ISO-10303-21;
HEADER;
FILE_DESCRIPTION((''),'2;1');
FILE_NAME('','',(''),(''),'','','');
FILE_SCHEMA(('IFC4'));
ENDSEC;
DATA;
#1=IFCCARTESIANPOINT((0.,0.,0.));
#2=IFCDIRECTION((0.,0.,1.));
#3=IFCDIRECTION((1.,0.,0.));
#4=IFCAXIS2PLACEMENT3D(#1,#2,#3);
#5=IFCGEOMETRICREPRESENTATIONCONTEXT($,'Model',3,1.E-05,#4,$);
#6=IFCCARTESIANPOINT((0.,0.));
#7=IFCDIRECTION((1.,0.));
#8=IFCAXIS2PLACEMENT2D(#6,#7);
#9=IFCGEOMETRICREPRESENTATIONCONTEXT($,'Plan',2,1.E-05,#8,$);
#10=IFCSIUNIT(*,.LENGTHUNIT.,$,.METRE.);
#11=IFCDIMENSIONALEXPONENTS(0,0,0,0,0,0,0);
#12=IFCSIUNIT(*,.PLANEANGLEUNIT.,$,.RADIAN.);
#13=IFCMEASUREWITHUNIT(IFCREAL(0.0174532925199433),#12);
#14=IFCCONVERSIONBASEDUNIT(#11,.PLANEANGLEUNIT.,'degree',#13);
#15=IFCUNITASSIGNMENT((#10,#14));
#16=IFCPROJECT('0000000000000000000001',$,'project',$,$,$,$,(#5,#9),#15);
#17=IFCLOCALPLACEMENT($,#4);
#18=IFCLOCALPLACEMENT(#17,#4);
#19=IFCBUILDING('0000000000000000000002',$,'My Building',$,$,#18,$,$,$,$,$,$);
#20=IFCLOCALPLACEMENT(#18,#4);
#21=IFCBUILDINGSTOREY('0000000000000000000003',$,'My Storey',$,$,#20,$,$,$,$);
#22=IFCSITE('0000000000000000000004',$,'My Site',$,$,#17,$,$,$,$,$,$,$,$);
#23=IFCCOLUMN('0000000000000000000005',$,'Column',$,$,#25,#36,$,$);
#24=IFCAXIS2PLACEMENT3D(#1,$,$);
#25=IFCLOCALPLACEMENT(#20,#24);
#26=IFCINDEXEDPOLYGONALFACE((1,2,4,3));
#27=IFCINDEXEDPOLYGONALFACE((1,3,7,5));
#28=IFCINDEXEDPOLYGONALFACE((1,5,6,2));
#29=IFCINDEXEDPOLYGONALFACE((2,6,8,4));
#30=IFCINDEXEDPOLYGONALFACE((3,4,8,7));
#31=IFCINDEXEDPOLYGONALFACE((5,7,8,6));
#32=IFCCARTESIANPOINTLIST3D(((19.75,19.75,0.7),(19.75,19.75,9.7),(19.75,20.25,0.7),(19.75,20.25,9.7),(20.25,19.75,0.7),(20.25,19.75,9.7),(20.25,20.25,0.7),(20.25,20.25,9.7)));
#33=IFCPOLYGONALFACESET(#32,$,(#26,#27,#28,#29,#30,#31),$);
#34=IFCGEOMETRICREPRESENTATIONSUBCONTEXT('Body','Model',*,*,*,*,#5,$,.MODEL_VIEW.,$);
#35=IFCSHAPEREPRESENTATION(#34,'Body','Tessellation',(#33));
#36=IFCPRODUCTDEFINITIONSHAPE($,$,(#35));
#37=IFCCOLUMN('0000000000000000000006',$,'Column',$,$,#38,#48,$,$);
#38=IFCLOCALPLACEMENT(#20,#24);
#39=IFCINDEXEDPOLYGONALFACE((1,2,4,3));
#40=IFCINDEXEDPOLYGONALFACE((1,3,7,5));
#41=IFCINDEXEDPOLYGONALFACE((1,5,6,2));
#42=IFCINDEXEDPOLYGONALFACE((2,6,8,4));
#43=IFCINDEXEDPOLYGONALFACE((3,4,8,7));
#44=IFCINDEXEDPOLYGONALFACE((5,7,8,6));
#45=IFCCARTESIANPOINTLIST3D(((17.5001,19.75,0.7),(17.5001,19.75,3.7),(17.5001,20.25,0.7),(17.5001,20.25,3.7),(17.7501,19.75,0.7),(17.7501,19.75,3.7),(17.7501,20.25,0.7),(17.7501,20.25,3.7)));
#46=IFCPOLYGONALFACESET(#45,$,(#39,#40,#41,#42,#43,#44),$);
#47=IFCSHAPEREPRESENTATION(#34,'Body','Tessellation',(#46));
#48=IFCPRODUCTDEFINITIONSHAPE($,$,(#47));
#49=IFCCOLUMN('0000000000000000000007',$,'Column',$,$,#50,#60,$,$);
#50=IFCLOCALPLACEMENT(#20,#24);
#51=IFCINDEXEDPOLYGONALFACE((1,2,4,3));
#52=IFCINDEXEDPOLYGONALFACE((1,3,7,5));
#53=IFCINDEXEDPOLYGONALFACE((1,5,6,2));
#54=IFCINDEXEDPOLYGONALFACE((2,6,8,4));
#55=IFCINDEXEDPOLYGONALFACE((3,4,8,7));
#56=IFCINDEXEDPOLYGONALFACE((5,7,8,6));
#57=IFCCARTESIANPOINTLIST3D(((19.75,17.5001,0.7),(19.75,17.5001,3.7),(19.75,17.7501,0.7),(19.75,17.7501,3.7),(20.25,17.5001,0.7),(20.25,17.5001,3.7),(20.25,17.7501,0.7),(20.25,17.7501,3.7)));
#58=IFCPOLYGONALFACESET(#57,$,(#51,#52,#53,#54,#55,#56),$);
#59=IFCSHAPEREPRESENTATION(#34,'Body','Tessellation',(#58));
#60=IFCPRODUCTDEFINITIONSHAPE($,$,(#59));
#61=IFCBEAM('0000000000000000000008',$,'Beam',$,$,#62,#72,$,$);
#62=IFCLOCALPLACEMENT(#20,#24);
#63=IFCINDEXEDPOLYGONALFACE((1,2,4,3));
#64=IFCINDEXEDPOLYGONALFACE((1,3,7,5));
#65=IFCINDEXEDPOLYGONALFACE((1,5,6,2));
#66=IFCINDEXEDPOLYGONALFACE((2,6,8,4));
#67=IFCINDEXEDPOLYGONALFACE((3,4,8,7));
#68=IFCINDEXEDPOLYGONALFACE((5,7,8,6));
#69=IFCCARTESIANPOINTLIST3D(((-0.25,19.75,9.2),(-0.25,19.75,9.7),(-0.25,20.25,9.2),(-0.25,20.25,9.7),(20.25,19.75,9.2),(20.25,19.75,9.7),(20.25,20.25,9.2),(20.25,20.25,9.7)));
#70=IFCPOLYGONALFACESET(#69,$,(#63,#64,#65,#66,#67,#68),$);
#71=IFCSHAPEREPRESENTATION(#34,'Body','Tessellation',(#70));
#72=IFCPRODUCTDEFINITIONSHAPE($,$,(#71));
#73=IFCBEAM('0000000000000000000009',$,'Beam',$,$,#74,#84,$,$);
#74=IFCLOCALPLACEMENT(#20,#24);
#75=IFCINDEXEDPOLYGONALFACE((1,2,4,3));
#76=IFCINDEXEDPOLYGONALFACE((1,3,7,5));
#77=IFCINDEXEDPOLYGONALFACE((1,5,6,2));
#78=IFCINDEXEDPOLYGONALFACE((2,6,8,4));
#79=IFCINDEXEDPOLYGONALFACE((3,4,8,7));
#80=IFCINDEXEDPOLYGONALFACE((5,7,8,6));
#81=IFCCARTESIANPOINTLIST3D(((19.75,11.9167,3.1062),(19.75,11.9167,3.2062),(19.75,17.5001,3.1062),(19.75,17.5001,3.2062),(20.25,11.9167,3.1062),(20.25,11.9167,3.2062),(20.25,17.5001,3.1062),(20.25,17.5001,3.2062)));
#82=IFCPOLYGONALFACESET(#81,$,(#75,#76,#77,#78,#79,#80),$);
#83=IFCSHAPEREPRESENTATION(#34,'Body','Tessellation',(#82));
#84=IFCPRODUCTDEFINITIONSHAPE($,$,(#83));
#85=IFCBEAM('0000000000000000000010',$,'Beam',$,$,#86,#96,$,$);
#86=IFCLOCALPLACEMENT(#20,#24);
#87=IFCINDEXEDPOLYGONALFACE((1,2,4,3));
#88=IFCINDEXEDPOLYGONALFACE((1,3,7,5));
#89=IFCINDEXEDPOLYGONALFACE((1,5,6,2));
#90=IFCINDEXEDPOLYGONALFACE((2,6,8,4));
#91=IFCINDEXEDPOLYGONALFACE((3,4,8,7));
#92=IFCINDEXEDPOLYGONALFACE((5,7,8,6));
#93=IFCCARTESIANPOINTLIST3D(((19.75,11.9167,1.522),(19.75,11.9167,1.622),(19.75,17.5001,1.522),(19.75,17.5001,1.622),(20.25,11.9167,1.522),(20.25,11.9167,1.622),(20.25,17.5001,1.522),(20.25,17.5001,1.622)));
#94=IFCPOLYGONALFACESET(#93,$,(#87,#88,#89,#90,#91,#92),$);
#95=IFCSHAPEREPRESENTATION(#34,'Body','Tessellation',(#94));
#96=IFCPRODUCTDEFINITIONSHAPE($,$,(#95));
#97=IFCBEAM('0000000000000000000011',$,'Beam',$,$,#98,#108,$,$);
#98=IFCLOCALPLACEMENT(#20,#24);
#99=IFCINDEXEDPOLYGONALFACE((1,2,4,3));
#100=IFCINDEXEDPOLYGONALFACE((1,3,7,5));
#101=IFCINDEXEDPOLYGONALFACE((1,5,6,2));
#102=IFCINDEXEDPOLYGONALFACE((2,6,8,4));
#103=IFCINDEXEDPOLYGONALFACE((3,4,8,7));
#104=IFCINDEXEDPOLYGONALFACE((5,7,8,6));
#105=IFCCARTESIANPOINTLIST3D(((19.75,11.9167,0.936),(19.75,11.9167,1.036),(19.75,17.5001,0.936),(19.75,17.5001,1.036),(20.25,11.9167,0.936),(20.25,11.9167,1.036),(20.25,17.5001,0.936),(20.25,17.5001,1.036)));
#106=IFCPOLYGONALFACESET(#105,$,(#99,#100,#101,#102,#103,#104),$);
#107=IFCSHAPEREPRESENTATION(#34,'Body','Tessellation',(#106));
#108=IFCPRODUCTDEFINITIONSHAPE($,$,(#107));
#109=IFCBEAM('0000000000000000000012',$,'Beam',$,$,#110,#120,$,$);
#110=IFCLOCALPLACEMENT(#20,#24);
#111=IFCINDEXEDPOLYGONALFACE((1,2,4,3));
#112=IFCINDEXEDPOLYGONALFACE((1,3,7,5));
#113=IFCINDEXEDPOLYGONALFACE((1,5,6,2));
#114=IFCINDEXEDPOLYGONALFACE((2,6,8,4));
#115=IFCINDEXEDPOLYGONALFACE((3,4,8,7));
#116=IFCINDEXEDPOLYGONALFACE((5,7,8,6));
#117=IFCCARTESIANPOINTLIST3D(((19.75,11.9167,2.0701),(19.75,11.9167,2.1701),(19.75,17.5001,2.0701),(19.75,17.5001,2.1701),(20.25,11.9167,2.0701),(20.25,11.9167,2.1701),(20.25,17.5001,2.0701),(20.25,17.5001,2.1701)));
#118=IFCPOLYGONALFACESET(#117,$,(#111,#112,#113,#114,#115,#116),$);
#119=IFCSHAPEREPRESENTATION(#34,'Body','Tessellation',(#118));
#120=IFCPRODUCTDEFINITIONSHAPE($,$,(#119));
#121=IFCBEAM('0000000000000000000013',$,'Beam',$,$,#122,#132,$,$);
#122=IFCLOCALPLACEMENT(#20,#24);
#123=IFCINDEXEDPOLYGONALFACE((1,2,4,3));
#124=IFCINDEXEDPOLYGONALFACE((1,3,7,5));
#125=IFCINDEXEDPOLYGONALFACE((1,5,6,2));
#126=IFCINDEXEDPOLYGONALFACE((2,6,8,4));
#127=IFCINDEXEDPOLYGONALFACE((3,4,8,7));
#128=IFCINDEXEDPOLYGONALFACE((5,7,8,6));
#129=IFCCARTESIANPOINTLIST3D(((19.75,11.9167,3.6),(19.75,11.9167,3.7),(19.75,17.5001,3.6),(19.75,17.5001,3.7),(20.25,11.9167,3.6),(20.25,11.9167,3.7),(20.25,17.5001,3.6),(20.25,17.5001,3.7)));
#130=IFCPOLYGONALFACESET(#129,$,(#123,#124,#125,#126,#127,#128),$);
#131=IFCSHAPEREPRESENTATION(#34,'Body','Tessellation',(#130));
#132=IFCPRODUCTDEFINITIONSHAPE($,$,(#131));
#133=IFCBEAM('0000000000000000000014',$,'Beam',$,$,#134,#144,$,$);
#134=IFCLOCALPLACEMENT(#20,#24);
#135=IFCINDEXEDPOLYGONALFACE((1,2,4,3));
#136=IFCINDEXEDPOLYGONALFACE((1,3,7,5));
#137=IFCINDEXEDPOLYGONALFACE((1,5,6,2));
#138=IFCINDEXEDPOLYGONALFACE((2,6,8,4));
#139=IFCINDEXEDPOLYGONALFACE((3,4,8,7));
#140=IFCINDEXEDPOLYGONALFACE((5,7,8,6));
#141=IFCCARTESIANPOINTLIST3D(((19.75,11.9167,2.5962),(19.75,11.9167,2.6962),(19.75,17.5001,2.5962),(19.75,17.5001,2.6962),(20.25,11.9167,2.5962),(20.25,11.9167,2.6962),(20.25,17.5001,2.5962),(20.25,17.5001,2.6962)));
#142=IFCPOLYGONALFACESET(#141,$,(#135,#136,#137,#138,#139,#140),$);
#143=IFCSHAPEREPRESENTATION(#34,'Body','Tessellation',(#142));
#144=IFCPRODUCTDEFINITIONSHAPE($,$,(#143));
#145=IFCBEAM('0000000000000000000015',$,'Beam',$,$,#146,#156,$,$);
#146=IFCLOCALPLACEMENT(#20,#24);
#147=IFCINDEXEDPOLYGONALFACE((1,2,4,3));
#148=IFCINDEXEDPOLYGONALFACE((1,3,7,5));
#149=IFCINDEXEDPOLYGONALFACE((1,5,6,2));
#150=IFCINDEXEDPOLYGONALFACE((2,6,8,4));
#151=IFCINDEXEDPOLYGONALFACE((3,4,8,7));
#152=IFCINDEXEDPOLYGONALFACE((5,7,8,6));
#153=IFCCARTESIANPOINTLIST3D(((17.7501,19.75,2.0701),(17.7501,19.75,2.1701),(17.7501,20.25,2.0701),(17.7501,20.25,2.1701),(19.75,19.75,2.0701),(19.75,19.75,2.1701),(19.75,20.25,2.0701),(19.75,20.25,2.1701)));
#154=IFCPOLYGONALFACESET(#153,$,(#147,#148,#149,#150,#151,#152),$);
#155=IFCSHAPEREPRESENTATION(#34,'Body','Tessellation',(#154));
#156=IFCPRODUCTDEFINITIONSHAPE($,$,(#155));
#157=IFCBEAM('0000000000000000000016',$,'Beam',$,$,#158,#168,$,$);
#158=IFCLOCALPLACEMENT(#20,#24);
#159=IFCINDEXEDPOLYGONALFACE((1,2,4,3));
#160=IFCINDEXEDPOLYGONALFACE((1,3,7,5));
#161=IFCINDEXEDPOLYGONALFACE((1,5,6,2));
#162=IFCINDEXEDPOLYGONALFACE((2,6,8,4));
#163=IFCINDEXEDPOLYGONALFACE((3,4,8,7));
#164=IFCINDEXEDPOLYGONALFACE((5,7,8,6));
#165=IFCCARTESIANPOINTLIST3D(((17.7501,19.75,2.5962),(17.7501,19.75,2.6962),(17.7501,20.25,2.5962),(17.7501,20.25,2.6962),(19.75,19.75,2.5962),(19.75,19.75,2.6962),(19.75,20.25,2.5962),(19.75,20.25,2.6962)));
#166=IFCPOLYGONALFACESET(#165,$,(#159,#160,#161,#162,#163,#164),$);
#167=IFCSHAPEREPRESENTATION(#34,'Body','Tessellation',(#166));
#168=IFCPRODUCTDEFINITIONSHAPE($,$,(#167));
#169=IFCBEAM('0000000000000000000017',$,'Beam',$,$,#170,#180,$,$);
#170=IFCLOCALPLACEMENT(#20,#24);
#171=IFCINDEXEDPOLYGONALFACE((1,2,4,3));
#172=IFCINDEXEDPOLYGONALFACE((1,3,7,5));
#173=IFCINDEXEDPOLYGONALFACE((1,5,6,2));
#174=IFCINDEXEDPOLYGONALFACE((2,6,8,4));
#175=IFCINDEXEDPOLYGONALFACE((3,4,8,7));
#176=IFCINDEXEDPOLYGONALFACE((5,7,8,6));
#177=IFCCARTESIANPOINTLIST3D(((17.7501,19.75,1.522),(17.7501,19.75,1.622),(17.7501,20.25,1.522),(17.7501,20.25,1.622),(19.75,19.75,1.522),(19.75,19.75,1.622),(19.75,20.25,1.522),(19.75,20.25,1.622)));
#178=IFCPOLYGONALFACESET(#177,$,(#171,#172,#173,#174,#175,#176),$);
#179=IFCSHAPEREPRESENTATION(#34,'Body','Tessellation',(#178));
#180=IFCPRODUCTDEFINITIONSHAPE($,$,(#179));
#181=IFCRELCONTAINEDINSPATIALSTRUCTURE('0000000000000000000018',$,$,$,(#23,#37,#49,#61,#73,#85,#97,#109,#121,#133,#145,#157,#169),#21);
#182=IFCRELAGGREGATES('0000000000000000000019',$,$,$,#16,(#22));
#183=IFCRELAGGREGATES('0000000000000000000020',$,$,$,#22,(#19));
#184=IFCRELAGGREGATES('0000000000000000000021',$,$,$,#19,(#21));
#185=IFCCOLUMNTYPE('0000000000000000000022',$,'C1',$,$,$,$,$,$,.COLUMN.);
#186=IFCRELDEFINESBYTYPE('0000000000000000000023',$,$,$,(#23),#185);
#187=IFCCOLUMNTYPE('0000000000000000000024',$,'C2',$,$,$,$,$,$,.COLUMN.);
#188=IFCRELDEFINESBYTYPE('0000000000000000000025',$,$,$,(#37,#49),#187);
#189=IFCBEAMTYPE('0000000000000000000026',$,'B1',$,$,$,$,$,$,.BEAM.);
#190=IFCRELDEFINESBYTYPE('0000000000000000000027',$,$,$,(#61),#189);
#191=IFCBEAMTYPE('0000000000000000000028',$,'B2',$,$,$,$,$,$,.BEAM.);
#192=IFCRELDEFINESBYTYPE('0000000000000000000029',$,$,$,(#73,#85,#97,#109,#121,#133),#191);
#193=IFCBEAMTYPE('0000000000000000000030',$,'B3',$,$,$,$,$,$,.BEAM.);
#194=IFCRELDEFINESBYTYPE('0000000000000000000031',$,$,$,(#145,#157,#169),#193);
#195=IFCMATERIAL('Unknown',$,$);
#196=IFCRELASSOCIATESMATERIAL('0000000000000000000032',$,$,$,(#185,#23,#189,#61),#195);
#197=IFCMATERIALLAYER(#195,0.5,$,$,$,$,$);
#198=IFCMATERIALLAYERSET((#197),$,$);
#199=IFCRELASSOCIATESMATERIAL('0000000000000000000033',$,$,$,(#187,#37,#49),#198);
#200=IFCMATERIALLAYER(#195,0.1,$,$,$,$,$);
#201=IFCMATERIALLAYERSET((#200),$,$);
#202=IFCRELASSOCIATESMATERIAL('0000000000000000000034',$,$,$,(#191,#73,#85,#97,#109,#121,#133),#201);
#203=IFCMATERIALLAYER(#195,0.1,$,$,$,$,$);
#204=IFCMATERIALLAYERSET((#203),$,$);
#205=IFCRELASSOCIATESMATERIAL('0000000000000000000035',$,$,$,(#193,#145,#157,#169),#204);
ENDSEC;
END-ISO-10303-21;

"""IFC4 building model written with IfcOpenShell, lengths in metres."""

from ifc_helpers import new_model, entity, si_unit, converted_unit, frame, origin_with_axes, origin_2d_with_axis, place, context, subcontext, project, spatial, line, indexed_curve, rectangle, outline, extrude, material, layer, layer_set, layer_usage, material_profile, profile_set, profile_usage, type_object, element, save


model = new_model("IFC4")

# Units and contexts
model_context = context("Model", 3, precision=1e-05, world=origin_with_axes())
plan_context = context("Plan", 2, precision=1e-05, world=origin_2d_with_axis())
body_context = subcontext(model_context, "Body", "Model", "MODEL_VIEW")
ifc_project = project(units=[si_unit("LENGTHUNIT", "METRE"), converted_unit("PLANEANGLEUNIT", "degree", entity("IfcReal", 0.0174532925199433), si_unit("PLANEANGLEUNIT", "RADIAN"), dimensions=[0, 0, 0, 0, 0, 0, 0])], contexts=[model_context, plan_context])

# Site, building, storey
site_placement = place(None, origin_with_axes())
site = spatial("IfcSite", under=ifc_project, at=site_placement, Name="My Site")
building_placement = place(site_placement, origin_with_axes())
building = spatial("IfcBuilding", under=site, at=building_placement, Name="My Building")
storey_placement = place(building_placement, origin_with_axes())
storey = spatial("IfcBuildingStorey", under=building, at=storey_placement, Name="My Storey")

# Columns
ifc_material = material(Name="Unknown")
ifc_material_profile_1 = material_profile(ifc_material, rectangle(XDim=0.5, YDim=0.5))
ifc_profile_set_1 = profile_set([ifc_material_profile_1])
ifc_profile_usage_1 = profile_usage(ifc_profile_set_1, cardinal=5)
column_type_1 = type_object("IfcColumnType", Name="C1", PredefinedType="COLUMN", material=ifc_profile_set_1)
column_1_placement = place(storey_placement, frame((20.0, 20.0, 0.7), z_axis=(0.0, 0.0, 1.0), x_axis=(1.0, 0.0, 0.0)))
element("IfcColumn", 1, at=column_1_placement, inside=storey, type_object=column_type_1, material=ifc_profile_usage_1, Name="Column", context=body_context, shape_type="SweptSolid", body=[
    extrude(rectangle(XDim=0.5, YDim=0.5), origin_with_axes(), (0.0, 0.0, 1.0), 9.0),
])
ifc_layer_1 = layer(ifc_material, 0.5)
ifc_layer_set_1 = layer_set([ifc_layer_1])
ifc_layer_usage_1 = layer_usage(ifc_layer_set_1, "AXIS2", "POSITIVE", 0.0)
column_type_2 = type_object("IfcColumnType", Name="C2", PredefinedType="COLUMN", material=ifc_layer_set_1)
column_2_placement = place(storey_placement, frame((17.5001, 19.75, 0.7), z_axis=(0.0, 0.0, 1.0), x_axis=(1.0, -0.000008, 0.0)))
element("IfcColumn", 2, at=column_2_placement, inside=storey, type_object=column_type_2, material=ifc_layer_usage_1, Name="Column", context=body_context, shape_type="SweptSolid", body=[
    extrude(outline(indexed_curve([(0.0, 0.0), (0.0, 0.5), (0.25, 0.5), (0.25, 0.0)], segments=[line(1, 2, 3, 4, 1)])), origin_with_axes(), (0.0, 0.0, 1.0), 3.0),
])
ifc_layer_usage_2 = layer_usage(ifc_layer_set_1, "AXIS2", "POSITIVE", 0.0)
column_3_placement = place(storey_placement, frame((20.25, 17.5001, 0.7), z_axis=(0.0, 0.0, 1.0), x_axis=(0.000007, 1.0, 0.0)))
element("IfcColumn", 3, at=column_3_placement, inside=storey, type_object=column_type_2, material=ifc_layer_usage_2, Name="Column", context=body_context, shape_type="SweptSolid", body=[
    extrude(outline(indexed_curve([(0.0, 0.0), (0.0, 0.5), (0.25, 0.5), (0.25, 0.0)], segments=[line(1, 2, 3, 4, 1)])), origin_with_axes(), (0.0, 0.0, 1.0), 3.0),
])

# Beams
ifc_material_profile_2 = material_profile(ifc_material, rectangle(XDim=0.5, YDim=0.5))
ifc_profile_set_2 = profile_set([ifc_material_profile_2])
ifc_profile_usage_2 = profile_usage(ifc_profile_set_2, cardinal=8)
beam_type_1 = type_object("IfcBeamType", Name="B1", PredefinedType="BEAM", material=ifc_profile_set_2)
beam_1_placement = place(storey_placement, frame((20.25, 20.0, 9.7), z_axis=(-1.0, -0.000001, 0.000001), x_axis=(0.000001, -1.0, 0.0)))
element("IfcBeam", 4, at=beam_1_placement, inside=storey, type_object=beam_type_1, material=ifc_profile_usage_2, Name="Beam", context=body_context, shape_type="SweptSolid", body=[
    extrude(rectangle(XDim=0.5, YDim=0.5), frame((0.0, -0.25, 0.0), z_axis=(0.0, 0.0, 1.0), x_axis=(1.0, 0.0, 0.0)), (0.0, 0.0, 1.0), 20.5),
])
ifc_layer_2 = layer(ifc_material, 0.1)
ifc_layer_set_2 = layer_set([ifc_layer_2])
ifc_layer_usage_3 = layer_usage(ifc_layer_set_2, "AXIS3", "POSITIVE", -0.1)
beam_type_2 = type_object("IfcBeamType", Name="B2", PredefinedType="BEAM", material=ifc_layer_set_2)
beam_2_placement = place(storey_placement, frame((19.75, 11.9167, 3.2062), z_axis=(0.0, 0.0, 1.0), x_axis=(0.0, 1.0, 0.0)))
element("IfcBeam", 5, at=beam_2_placement, inside=storey, type_object=beam_type_2, material=ifc_layer_usage_3, Name="Beam", context=body_context, shape_type="SweptSolid", body=[
    extrude(outline(indexed_curve([(0.0, 0.0), (0.0, -0.5), (5.5833, -0.5), (5.5834, 0.0), (0.0, 0.0)])), frame((0.0, 0.0, -0.1), z_axis=(0.0, 0.0, 1.0), x_axis=(1.0, 0.0, 0.0)), (0.0, 0.0, 1.0), 0.1),
])
ifc_layer_usage_4 = layer_usage(ifc_layer_set_2, "AXIS3", "POSITIVE", -0.1)
beam_3_placement = place(storey_placement, frame((19.75, 11.9167, 1.622), z_axis=(0.0, 0.0, 1.0), x_axis=(0.0, 1.0, 0.0)))
element("IfcBeam", 6, at=beam_3_placement, inside=storey, type_object=beam_type_2, material=ifc_layer_usage_4, Name="Beam", context=body_context, shape_type="SweptSolid", body=[
    extrude(outline(indexed_curve([(0.0, 0.0), (0.0, -0.5), (5.5833, -0.5), (5.5834, 0.0), (0.0, 0.0)])), frame((0.0, 0.0, -0.1), z_axis=(0.0, 0.0, 1.0), x_axis=(1.0, 0.0, 0.0)), (0.0, 0.0, 1.0), 0.1),
])
ifc_layer_usage_5 = layer_usage(ifc_layer_set_2, "AXIS3", "POSITIVE", -0.1)
beam_4_placement = place(storey_placement, frame((19.75, 11.9167, 1.036), z_axis=(0.0, 0.0, 1.0), x_axis=(0.0, 1.0, 0.0)))
element("IfcBeam", 7, at=beam_4_placement, inside=storey, type_object=beam_type_2, material=ifc_layer_usage_5, Name="Beam", context=body_context, shape_type="SweptSolid", body=[
    extrude(outline(indexed_curve([(0.0, 0.0), (0.0, -0.5), (5.5833, -0.5), (5.5834, 0.0), (0.0, 0.0)])), frame((0.0, 0.0, -0.1), z_axis=(0.0, 0.0, 1.0), x_axis=(1.0, 0.0, 0.0)), (0.0, 0.0, 1.0), 0.1),
])
ifc_layer_usage_6 = layer_usage(ifc_layer_set_2, "AXIS3", "POSITIVE", -0.1)
beam_5_placement = place(storey_placement, frame((19.75, 11.9167, 2.1701), z_axis=(0.0, 0.0, 1.0), x_axis=(0.0, 1.0, 0.0)))
element("IfcBeam", 8, at=beam_5_placement, inside=storey, type_object=beam_type_2, material=ifc_layer_usage_6, Name="Beam", context=body_context, shape_type="SweptSolid", body=[
    extrude(outline(indexed_curve([(0.0, 0.0), (0.0, -0.5), (5.5833, -0.5), (5.5834, 0.0), (0.0, 0.0)])), frame((0.0, 0.0, -0.1), z_axis=(0.0, 0.0, 1.0), x_axis=(1.0, 0.0, 0.0)), (0.0, 0.0, 1.0), 0.1),
])
ifc_layer_usage_7 = layer_usage(ifc_layer_set_2, "AXIS3", "POSITIVE", -0.1)
beam_6_placement = place(storey_placement, frame((19.75, 11.9167, 3.7), z_axis=(0.0, 0.0, 1.0), x_axis=(0.0, 1.0, 0.0)))
element("IfcBeam", 9, at=beam_6_placement, inside=storey, type_object=beam_type_2, material=ifc_layer_usage_7, Name="Beam", context=body_context, shape_type="SweptSolid", body=[
    extrude(outline(indexed_curve([(0.0, 0.0), (0.0, -0.5), (5.5833, -0.5), (5.5834, 0.0), (0.0, 0.0)])), frame((0.0, 0.0, -0.1), z_axis=(0.0, 0.0, 1.0), x_axis=(1.0, 0.0, 0.0)), (0.0, 0.0, 1.0), 0.1),
])
ifc_layer_usage_8 = layer_usage(ifc_layer_set_2, "AXIS3", "POSITIVE", -0.1)
beam_7_placement = place(storey_placement, frame((19.75, 11.9167, 2.6962), z_axis=(0.0, 0.0, 1.0), x_axis=(0.0, 1.0, 0.0)))
element("IfcBeam", 10, at=beam_7_placement, inside=storey, type_object=beam_type_2, material=ifc_layer_usage_8, Name="Beam", context=body_context, shape_type="SweptSolid", body=[
    extrude(outline(indexed_curve([(0.0, 0.0), (0.0, -0.5), (5.5833, -0.5), (5.5834, 0.0), (0.0, 0.0)])), frame((0.0, 0.0, -0.1), z_axis=(0.0, 0.0, 1.0), x_axis=(1.0, 0.0, 0.0)), (0.0, 0.0, 1.0), 0.1),
])
ifc_layer_3 = layer(ifc_material, 0.1)
ifc_layer_set_3 = layer_set([ifc_layer_3])
ifc_layer_usage_9 = layer_usage(ifc_layer_set_3, "AXIS3", "POSITIVE", -0.1)
beam_type_3 = type_object("IfcBeamType", Name="B3", PredefinedType="BEAM", material=ifc_layer_set_3)
beam_8_placement = place(storey_placement, frame((17.7501, 19.75, 2.1701), z_axis=(0.0, 0.0, 1.0), x_axis=(1.0, 0.0, 0.0)))
element("IfcBeam", 11, at=beam_8_placement, inside=storey, type_object=beam_type_3, material=ifc_layer_usage_9, Name="Beam", context=body_context, shape_type="SweptSolid", body=[
    extrude(outline(indexed_curve([(0.0, 0.0), (0.0, 0.5), (1.9999, 0.5), (1.9999, 0.0), (0.0, 0.0)])), frame((0.0, 0.0, -0.1), z_axis=(0.0, 0.0, 1.0), x_axis=(1.0, 0.0, 0.0)), (0.0, 0.0, 1.0), 0.1),
])
ifc_layer_usage_10 = layer_usage(ifc_layer_set_3, "AXIS3", "POSITIVE", -0.1)
beam_9_placement = place(storey_placement, frame((17.7501, 19.75, 2.6962), z_axis=(0.0, 0.0, 1.0), x_axis=(1.0, 0.0, 0.0)))
element("IfcBeam", 12, at=beam_9_placement, inside=storey, type_object=beam_type_3, material=ifc_layer_usage_10, Name="Beam", context=body_context, shape_type="SweptSolid", body=[
    extrude(outline(indexed_curve([(0.0, 0.0), (0.0, 0.5), (1.9999, 0.5), (1.9999, 0.0), (0.0, 0.0)])), frame((0.0, 0.0, -0.1), z_axis=(0.0, 0.0, 1.0), x_axis=(1.0, 0.0, 0.0)), (0.0, 0.0, 1.0), 0.1),
])
ifc_layer_usage_11 = layer_usage(ifc_layer_set_3, "AXIS3", "POSITIVE", -0.1)
beam_10_placement = place(storey_placement, frame((17.7501, 19.75, 1.622), z_axis=(0.0, 0.0, 1.0), x_axis=(1.0, 0.0, 0.0)))
element("IfcBeam", 13, at=beam_10_placement, inside=storey, type_object=beam_type_3, material=ifc_layer_usage_11, Name="Beam", context=body_context, shape_type="SweptSolid", body=[
    extrude(outline(indexed_curve([(0.0, 0.0), (0.0, 0.5), (1.9999, 0.5), (1.9999, 0.0), (0.0, 0.0)])), frame((0.0, 0.0, -0.1), z_axis=(0.0, 0.0, 1.0), x_axis=(1.0, 0.0, 0.0)), (0.0, 0.0, 1.0), 0.1),
])

save(model, "model.ifc")
